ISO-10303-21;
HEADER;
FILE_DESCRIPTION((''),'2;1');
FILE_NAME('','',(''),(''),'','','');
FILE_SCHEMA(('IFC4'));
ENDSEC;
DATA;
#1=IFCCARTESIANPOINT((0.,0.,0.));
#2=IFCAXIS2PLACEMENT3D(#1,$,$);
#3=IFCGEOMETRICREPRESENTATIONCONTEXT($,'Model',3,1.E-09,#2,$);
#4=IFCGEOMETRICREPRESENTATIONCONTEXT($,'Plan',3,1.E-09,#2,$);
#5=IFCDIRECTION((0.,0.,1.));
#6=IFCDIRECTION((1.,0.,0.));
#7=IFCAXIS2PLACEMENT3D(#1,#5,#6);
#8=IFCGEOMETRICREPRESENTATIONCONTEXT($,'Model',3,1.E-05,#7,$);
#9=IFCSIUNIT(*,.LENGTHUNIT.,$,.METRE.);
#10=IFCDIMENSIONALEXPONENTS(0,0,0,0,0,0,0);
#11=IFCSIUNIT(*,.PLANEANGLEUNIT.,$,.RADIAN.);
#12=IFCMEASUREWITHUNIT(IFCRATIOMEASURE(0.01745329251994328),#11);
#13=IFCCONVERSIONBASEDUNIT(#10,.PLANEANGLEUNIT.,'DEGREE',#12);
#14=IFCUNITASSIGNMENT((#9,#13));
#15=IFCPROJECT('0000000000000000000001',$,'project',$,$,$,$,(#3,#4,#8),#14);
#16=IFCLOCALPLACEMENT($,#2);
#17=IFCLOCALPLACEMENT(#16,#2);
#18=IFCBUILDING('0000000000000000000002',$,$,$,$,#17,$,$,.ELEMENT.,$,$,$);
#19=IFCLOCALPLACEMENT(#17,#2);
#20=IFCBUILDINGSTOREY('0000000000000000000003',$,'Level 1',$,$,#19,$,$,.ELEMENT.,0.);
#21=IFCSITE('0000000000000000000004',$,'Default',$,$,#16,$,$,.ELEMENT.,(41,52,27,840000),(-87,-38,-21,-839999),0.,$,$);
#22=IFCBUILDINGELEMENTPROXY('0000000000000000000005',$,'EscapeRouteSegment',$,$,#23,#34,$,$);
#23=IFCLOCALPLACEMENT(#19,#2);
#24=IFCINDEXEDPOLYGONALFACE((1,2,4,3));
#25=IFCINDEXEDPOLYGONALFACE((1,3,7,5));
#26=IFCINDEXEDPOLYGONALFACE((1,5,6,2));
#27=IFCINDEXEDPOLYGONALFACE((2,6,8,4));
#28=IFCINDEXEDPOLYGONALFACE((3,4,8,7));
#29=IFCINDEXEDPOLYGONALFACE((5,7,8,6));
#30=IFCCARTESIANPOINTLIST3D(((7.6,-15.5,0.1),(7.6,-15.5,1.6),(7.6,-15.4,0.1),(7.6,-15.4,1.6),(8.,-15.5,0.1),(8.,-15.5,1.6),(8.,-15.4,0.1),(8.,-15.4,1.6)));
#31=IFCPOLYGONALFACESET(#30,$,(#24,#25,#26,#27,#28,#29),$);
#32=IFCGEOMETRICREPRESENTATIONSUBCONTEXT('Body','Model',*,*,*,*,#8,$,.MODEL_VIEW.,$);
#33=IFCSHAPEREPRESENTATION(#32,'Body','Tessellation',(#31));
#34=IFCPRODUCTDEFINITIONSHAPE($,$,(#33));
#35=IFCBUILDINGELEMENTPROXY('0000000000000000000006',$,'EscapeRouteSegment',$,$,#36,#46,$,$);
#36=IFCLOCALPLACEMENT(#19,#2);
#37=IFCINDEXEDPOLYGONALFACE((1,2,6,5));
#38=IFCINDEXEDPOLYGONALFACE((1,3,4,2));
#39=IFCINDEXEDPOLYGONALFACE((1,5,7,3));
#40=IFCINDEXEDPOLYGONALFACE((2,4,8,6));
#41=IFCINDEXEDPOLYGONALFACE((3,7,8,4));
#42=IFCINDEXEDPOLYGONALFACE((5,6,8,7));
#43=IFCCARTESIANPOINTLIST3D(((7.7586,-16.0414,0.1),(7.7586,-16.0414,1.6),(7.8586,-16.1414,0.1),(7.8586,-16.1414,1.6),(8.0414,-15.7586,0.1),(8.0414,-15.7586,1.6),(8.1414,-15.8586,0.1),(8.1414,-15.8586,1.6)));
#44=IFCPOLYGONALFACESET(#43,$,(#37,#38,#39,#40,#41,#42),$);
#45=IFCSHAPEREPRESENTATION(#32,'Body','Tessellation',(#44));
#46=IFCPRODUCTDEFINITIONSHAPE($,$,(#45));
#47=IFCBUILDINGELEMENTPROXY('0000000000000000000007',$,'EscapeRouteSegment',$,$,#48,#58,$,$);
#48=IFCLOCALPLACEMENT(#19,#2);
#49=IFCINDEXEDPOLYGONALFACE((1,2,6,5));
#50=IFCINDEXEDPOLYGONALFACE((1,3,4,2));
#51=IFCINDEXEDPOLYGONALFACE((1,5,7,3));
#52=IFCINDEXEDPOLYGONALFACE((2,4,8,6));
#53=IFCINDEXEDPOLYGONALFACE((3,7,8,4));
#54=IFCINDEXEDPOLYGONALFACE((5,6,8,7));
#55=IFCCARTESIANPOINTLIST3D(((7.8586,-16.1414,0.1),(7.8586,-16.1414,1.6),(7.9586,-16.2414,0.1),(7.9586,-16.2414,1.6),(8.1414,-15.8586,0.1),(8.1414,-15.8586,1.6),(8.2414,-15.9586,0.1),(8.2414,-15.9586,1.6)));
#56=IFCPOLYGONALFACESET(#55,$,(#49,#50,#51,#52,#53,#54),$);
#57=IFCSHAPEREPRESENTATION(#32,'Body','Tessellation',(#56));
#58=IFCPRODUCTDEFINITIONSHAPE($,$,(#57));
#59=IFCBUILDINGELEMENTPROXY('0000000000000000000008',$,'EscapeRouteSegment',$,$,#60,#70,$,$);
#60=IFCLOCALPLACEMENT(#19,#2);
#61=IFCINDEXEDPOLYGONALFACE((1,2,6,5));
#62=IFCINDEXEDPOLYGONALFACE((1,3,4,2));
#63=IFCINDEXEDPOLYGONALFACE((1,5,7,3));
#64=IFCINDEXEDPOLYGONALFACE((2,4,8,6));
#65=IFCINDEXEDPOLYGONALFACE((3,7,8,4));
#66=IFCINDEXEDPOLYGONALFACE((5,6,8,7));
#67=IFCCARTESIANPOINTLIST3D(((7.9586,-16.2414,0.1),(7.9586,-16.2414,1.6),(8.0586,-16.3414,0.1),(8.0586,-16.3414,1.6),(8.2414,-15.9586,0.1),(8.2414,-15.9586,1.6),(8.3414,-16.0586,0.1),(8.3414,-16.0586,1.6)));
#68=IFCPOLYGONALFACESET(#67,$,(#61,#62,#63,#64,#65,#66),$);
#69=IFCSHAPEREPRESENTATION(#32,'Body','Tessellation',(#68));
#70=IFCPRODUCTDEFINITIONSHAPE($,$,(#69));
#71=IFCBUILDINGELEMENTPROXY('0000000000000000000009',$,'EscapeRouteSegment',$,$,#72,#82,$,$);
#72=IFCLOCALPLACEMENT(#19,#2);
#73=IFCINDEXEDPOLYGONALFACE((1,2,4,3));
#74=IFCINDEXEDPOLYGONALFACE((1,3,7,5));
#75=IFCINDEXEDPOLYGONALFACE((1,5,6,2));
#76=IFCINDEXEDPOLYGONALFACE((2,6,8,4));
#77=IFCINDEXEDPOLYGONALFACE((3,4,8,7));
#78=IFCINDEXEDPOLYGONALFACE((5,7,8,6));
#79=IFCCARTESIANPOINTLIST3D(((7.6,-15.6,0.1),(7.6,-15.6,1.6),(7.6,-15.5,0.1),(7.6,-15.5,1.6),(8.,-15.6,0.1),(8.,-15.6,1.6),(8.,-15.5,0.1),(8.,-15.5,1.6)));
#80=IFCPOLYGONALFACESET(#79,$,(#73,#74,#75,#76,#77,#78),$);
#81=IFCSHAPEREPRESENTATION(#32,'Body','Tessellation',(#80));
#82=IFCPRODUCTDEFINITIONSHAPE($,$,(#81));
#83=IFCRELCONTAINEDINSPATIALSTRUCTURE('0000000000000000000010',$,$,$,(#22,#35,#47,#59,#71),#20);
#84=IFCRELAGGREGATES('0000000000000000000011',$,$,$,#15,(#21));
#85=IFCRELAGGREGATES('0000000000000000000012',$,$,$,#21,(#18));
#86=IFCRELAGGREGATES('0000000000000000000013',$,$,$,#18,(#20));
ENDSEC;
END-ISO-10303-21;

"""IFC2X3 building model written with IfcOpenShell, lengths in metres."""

from ifc_helpers import new_model, entity, si_unit, converted_unit, frame, origin, origin_with_axes, place, context, subcontext, project, spatial, polyline, outline, extrude, element, save


model = new_model("IFC2X3")

# Units and contexts
model_context_1 = context("Model", 3, precision=1e-09, world=origin())
plan_context = context("Plan", 3, precision=1e-09, world=origin())
model_context_2 = context("Model", 3, precision=1e-05, world=origin_with_axes())
body_context = subcontext(model_context_2, "Body", "Model", "MODEL_VIEW")
ifc_project = project(units=[si_unit("LENGTHUNIT", "METRE"), converted_unit("PLANEANGLEUNIT", "DEGREE", entity("IfcRatioMeasure", 0.01745329251994328), si_unit("PLANEANGLEUNIT", "RADIAN"), dimensions=[0, 0, 0, 0, 0, 0, 0])], contexts=[model_context_1, plan_context, model_context_2])

# Site, building, storey
site_placement = place(None, origin())
site = spatial("IfcSite", under=ifc_project, at=site_placement, Name="Default", CompositionType="ELEMENT", RefLatitude=(41, 52, 27, 840000), RefLongitude=(-87, -38, -21, -839999), RefElevation=0.0)
building_placement = place(site_placement, origin())
building = spatial("IfcBuilding", under=site, at=building_placement, CompositionType="ELEMENT")
storey_placement = place(building_placement, origin())
storey = spatial("IfcBuildingStorey", under=building, at=storey_placement, Name="Level 1", CompositionType="ELEMENT", Elevation=0.0)

# Building element proxies
proxy_1_placement = place(storey_placement, frame((7.8, -15.4, 0.1), z_axis=(0.0, 0.0, 1.0), x_axis=(0.0, -1.0, 0.0)))
element("IfcBuildingElementProxy", 1, at=proxy_1_placement, inside=storey, Name="EscapeRouteSegment", context=body_context, shape_type="SweptSolid", body=[
    extrude(outline(polyline([(0.0, -0.2), (0.0, 0.2), (0.1, 0.2), (0.1, -0.2), (0.0, -0.2)])), origin_with_axes(), (0.0, 0.0, 1.0), 1.5),
])
proxy_2_placement = place(storey_placement, frame((7.9, -15.9, 0.1), z_axis=(0.0, 0.0, 1.0), x_axis=(0.707105, -0.707108, 0.0)))
element("IfcBuildingElementProxy", 2, at=proxy_2_placement, inside=storey, Name="EscapeRouteSegment", context=body_context, shape_type="SweptSolid", body=[
    extrude(outline(polyline([(0.0, -0.2), (0.0, 0.2), (0.1414, 0.2), (0.1414, -0.2), (0.0, -0.2)])), origin_with_axes(), (0.0, 0.0, 1.0), 1.5),
])
proxy_3_placement = place(storey_placement, frame((8.0, -16.0, 0.1), z_axis=(0.0, 0.0, 1.0), x_axis=(0.707107, -0.707107, 0.0)))
element("IfcBuildingElementProxy", 3, at=proxy_3_placement, inside=storey, Name="EscapeRouteSegment", context=body_context, shape_type="SweptSolid", body=[
    extrude(outline(polyline([(0.0, -0.2), (0.0, 0.2), (0.1414, 0.2), (0.1414, -0.2), (0.0, -0.2)])), origin_with_axes(), (0.0, 0.0, 1.0), 1.5),
])
proxy_4_placement = place(storey_placement, frame((8.1, -16.1, 0.1), z_axis=(0.0, 0.0, 1.0), x_axis=(0.707103, -0.70711, 0.0)))
element("IfcBuildingElementProxy", 4, at=proxy_4_placement, inside=storey, Name="EscapeRouteSegment", context=body_context, shape_type="SweptSolid", body=[
    extrude(outline(polyline([(0.0, -0.2), (0.0, 0.2), (0.1414, 0.2), (0.1414, -0.2), (0.0, -0.2)])), origin_with_axes(), (0.0, 0.0, 1.0), 1.5),
])
for number, where, z_axis, x_axis, name in (
    (5, (7.8, -15.5, 0.1), (0.0, 0.0, 1.0), (0.0, -1.0, 0.0), "EscapeRouteSegment"),
):
    element("IfcBuildingElementProxy", number, at=place(storey_placement, frame(where, z_axis=z_axis, x_axis=x_axis)), inside=storey, Name=name, context=body_context, shape_type="SweptSolid", body=[
        extrude(outline(polyline([(0.0, -0.2), (0.0, 0.2), (0.1, 0.2), (0.1, -0.2), (0.0, -0.2)])), origin_with_axes(), (0.0, 0.0, 1.0), 1.5),
    ])

save(model, "model.ifc")
